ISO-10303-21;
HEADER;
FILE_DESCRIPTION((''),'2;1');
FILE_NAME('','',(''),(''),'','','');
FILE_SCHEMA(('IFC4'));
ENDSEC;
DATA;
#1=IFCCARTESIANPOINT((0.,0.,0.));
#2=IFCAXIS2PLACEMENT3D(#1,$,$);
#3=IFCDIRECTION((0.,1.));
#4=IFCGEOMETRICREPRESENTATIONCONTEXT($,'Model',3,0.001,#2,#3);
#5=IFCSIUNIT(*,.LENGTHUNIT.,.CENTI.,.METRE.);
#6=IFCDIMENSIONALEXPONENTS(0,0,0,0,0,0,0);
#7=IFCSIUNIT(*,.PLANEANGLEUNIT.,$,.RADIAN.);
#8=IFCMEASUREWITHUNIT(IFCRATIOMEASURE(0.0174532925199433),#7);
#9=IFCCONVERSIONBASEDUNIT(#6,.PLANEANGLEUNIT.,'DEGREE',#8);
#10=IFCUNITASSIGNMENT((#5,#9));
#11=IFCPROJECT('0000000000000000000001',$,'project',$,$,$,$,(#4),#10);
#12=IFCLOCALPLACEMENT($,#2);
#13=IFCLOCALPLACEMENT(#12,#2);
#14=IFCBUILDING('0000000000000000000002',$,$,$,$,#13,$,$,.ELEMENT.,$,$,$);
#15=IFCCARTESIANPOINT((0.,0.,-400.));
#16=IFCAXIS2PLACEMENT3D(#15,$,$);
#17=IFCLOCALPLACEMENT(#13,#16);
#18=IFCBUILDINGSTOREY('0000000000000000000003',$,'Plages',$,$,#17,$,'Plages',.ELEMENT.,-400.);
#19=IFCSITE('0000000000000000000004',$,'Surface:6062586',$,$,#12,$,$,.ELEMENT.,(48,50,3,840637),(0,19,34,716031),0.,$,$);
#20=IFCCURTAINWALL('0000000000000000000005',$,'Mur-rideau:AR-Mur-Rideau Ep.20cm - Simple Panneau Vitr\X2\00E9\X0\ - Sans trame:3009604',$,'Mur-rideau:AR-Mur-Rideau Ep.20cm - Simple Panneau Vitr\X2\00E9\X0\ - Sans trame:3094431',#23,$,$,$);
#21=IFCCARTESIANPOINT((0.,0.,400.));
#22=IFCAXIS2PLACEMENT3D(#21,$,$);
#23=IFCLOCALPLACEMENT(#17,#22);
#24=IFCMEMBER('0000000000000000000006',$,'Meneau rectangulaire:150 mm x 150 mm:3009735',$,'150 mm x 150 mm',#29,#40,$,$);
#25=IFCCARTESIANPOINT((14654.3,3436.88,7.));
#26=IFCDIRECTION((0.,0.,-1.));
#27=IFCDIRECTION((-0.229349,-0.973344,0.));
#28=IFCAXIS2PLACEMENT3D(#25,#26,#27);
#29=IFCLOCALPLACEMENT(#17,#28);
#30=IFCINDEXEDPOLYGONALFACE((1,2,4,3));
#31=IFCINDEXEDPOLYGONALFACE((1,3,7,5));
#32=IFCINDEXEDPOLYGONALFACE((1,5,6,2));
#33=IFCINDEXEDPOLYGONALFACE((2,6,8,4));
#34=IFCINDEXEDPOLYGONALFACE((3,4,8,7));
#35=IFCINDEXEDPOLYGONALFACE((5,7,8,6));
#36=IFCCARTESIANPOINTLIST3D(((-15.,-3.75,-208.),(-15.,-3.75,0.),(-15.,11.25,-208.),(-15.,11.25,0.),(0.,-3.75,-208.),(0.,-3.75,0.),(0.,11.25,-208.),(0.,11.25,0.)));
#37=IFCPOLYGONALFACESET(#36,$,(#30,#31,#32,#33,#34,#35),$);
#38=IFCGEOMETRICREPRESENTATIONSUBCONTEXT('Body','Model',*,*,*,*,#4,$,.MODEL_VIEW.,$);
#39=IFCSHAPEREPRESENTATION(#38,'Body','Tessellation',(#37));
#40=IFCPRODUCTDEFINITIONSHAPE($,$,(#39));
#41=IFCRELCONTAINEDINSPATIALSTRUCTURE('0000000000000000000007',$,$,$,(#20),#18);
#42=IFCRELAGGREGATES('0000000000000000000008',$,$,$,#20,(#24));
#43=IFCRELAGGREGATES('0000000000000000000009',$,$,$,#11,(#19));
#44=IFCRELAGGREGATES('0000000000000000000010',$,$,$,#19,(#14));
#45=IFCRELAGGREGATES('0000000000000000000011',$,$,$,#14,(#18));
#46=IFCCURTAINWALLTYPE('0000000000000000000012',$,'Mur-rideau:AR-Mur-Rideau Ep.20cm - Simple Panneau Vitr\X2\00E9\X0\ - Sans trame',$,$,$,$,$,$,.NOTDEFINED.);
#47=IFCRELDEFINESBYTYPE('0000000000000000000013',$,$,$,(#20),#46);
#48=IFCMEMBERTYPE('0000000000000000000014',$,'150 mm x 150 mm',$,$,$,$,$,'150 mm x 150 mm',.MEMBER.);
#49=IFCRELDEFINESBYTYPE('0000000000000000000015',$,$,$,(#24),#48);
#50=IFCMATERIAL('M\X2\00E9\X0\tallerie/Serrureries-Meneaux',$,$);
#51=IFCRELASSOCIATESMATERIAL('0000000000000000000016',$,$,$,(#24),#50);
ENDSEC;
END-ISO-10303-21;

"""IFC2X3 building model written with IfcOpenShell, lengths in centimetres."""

from ifc_helpers import new_model, entity, si_unit, converted_unit, direction, frame, origin, origin_2d_with_axis, place, context, subcontext, project, spatial, rectangle, extrude, source, transform, mapped, material, type_object, type_shapes, element, aggregate, save


model = new_model("IFC2X3")

# Units and contexts
model_context = context("Model", 3, precision=0.001, world=origin(), true_north=direction((0.0, 1.0)))
body_context = subcontext(model_context, "Body", "Model", "MODEL_VIEW")
ifc_project = project(units=[si_unit("LENGTHUNIT", "METRE", prefix="CENTI"), converted_unit("PLANEANGLEUNIT", "DEGREE", entity("IfcRatioMeasure", 0.0174532925199433), si_unit("PLANEANGLEUNIT", "RADIAN"), dimensions=[0, 0, 0, 0, 0, 0, 0])], contexts=[model_context])

# Site, building, storey
site_placement = place(None, origin())
site = spatial("IfcSite", under=ifc_project, at=site_placement, Name="Surface:6062586", CompositionType="ELEMENT", RefLatitude=(48, 50, 3, 840637), RefLongitude=(0, 19, 34, 716031), RefElevation=0.0)
building_placement = place(site_placement, origin())
building = spatial("IfcBuilding", under=site, at=building_placement, CompositionType="ELEMENT")
storey_placement = place(building_placement, frame((0.0, 0.0, -400.0)))
storey = spatial("IfcBuildingStorey", under=building, at=storey_placement, Name="Plages", LongName="Plages", CompositionType="ELEMENT", Elevation=-400.0)

# Curtain wall, member
curtain_wall_type_1 = type_object("IfcCurtainWallType", Name="Mur-rideau:AR-Mur-Rideau Ep.20cm - Simple Panneau Vitré - Sans trame", PredefinedType="NOTDEFINED")
ifc_material_1 = material(Name="Métallerie/Serrureries-Meneaux")
curtain_wall_1_placement = place(storey_placement, frame((0.0, 0.0, 400.0)))
curtain_wall_1 = element("IfcCurtainWall", 1, at=curtain_wall_1_placement, inside=storey, type_object=curtain_wall_type_1, Name="Mur-rideau:AR-Mur-Rideau Ep.20cm - Simple Panneau Vitré - Sans trame:3009604", ObjectType="Mur-rideau:AR-Mur-Rideau Ep.20cm - Simple Panneau Vitré - Sans trame:3094431")
member_type_1 = type_object("IfcMemberType", Name="150 mm x 150 mm", ElementType="150 mm x 150 mm", PredefinedType="MEMBER")
shared_shape_1 = source(origin(), body_context, "Body", "SweptSolid", [
    extrude(rectangle(XDim=15.0, YDim=15.0, at=origin_2d_with_axis()), frame((-7.5, 3.75, -208.0), z_axis=(0.0, 0.0, 1.0), x_axis=(0.0, -1.0, 0.0)), (0.0, 0.0, 1.0), 208.0),
])
type_shapes(member_type_1, [shared_shape_1])
member_1_placement = place(storey_placement, frame((14654.3, 3436.88, 7.0), z_axis=(0.0, 0.0, -1.0), x_axis=(-0.229349, -0.973344, 0.0)))
member_1 = element("IfcMember", 2, at=member_1_placement, type_object=member_type_1, material=ifc_material_1, Name="Meneau rectangulaire:150 mm x 150 mm:3009735", ObjectType="150 mm x 150 mm", context=body_context, shape_type="MappedRepresentation", body=[
    mapped(shared_shape_1, transform((0.0, 0.0, 0.0), scale=1.0)),
])
aggregate(curtain_wall_1, [member_1])

save(model, "model.ifc")
